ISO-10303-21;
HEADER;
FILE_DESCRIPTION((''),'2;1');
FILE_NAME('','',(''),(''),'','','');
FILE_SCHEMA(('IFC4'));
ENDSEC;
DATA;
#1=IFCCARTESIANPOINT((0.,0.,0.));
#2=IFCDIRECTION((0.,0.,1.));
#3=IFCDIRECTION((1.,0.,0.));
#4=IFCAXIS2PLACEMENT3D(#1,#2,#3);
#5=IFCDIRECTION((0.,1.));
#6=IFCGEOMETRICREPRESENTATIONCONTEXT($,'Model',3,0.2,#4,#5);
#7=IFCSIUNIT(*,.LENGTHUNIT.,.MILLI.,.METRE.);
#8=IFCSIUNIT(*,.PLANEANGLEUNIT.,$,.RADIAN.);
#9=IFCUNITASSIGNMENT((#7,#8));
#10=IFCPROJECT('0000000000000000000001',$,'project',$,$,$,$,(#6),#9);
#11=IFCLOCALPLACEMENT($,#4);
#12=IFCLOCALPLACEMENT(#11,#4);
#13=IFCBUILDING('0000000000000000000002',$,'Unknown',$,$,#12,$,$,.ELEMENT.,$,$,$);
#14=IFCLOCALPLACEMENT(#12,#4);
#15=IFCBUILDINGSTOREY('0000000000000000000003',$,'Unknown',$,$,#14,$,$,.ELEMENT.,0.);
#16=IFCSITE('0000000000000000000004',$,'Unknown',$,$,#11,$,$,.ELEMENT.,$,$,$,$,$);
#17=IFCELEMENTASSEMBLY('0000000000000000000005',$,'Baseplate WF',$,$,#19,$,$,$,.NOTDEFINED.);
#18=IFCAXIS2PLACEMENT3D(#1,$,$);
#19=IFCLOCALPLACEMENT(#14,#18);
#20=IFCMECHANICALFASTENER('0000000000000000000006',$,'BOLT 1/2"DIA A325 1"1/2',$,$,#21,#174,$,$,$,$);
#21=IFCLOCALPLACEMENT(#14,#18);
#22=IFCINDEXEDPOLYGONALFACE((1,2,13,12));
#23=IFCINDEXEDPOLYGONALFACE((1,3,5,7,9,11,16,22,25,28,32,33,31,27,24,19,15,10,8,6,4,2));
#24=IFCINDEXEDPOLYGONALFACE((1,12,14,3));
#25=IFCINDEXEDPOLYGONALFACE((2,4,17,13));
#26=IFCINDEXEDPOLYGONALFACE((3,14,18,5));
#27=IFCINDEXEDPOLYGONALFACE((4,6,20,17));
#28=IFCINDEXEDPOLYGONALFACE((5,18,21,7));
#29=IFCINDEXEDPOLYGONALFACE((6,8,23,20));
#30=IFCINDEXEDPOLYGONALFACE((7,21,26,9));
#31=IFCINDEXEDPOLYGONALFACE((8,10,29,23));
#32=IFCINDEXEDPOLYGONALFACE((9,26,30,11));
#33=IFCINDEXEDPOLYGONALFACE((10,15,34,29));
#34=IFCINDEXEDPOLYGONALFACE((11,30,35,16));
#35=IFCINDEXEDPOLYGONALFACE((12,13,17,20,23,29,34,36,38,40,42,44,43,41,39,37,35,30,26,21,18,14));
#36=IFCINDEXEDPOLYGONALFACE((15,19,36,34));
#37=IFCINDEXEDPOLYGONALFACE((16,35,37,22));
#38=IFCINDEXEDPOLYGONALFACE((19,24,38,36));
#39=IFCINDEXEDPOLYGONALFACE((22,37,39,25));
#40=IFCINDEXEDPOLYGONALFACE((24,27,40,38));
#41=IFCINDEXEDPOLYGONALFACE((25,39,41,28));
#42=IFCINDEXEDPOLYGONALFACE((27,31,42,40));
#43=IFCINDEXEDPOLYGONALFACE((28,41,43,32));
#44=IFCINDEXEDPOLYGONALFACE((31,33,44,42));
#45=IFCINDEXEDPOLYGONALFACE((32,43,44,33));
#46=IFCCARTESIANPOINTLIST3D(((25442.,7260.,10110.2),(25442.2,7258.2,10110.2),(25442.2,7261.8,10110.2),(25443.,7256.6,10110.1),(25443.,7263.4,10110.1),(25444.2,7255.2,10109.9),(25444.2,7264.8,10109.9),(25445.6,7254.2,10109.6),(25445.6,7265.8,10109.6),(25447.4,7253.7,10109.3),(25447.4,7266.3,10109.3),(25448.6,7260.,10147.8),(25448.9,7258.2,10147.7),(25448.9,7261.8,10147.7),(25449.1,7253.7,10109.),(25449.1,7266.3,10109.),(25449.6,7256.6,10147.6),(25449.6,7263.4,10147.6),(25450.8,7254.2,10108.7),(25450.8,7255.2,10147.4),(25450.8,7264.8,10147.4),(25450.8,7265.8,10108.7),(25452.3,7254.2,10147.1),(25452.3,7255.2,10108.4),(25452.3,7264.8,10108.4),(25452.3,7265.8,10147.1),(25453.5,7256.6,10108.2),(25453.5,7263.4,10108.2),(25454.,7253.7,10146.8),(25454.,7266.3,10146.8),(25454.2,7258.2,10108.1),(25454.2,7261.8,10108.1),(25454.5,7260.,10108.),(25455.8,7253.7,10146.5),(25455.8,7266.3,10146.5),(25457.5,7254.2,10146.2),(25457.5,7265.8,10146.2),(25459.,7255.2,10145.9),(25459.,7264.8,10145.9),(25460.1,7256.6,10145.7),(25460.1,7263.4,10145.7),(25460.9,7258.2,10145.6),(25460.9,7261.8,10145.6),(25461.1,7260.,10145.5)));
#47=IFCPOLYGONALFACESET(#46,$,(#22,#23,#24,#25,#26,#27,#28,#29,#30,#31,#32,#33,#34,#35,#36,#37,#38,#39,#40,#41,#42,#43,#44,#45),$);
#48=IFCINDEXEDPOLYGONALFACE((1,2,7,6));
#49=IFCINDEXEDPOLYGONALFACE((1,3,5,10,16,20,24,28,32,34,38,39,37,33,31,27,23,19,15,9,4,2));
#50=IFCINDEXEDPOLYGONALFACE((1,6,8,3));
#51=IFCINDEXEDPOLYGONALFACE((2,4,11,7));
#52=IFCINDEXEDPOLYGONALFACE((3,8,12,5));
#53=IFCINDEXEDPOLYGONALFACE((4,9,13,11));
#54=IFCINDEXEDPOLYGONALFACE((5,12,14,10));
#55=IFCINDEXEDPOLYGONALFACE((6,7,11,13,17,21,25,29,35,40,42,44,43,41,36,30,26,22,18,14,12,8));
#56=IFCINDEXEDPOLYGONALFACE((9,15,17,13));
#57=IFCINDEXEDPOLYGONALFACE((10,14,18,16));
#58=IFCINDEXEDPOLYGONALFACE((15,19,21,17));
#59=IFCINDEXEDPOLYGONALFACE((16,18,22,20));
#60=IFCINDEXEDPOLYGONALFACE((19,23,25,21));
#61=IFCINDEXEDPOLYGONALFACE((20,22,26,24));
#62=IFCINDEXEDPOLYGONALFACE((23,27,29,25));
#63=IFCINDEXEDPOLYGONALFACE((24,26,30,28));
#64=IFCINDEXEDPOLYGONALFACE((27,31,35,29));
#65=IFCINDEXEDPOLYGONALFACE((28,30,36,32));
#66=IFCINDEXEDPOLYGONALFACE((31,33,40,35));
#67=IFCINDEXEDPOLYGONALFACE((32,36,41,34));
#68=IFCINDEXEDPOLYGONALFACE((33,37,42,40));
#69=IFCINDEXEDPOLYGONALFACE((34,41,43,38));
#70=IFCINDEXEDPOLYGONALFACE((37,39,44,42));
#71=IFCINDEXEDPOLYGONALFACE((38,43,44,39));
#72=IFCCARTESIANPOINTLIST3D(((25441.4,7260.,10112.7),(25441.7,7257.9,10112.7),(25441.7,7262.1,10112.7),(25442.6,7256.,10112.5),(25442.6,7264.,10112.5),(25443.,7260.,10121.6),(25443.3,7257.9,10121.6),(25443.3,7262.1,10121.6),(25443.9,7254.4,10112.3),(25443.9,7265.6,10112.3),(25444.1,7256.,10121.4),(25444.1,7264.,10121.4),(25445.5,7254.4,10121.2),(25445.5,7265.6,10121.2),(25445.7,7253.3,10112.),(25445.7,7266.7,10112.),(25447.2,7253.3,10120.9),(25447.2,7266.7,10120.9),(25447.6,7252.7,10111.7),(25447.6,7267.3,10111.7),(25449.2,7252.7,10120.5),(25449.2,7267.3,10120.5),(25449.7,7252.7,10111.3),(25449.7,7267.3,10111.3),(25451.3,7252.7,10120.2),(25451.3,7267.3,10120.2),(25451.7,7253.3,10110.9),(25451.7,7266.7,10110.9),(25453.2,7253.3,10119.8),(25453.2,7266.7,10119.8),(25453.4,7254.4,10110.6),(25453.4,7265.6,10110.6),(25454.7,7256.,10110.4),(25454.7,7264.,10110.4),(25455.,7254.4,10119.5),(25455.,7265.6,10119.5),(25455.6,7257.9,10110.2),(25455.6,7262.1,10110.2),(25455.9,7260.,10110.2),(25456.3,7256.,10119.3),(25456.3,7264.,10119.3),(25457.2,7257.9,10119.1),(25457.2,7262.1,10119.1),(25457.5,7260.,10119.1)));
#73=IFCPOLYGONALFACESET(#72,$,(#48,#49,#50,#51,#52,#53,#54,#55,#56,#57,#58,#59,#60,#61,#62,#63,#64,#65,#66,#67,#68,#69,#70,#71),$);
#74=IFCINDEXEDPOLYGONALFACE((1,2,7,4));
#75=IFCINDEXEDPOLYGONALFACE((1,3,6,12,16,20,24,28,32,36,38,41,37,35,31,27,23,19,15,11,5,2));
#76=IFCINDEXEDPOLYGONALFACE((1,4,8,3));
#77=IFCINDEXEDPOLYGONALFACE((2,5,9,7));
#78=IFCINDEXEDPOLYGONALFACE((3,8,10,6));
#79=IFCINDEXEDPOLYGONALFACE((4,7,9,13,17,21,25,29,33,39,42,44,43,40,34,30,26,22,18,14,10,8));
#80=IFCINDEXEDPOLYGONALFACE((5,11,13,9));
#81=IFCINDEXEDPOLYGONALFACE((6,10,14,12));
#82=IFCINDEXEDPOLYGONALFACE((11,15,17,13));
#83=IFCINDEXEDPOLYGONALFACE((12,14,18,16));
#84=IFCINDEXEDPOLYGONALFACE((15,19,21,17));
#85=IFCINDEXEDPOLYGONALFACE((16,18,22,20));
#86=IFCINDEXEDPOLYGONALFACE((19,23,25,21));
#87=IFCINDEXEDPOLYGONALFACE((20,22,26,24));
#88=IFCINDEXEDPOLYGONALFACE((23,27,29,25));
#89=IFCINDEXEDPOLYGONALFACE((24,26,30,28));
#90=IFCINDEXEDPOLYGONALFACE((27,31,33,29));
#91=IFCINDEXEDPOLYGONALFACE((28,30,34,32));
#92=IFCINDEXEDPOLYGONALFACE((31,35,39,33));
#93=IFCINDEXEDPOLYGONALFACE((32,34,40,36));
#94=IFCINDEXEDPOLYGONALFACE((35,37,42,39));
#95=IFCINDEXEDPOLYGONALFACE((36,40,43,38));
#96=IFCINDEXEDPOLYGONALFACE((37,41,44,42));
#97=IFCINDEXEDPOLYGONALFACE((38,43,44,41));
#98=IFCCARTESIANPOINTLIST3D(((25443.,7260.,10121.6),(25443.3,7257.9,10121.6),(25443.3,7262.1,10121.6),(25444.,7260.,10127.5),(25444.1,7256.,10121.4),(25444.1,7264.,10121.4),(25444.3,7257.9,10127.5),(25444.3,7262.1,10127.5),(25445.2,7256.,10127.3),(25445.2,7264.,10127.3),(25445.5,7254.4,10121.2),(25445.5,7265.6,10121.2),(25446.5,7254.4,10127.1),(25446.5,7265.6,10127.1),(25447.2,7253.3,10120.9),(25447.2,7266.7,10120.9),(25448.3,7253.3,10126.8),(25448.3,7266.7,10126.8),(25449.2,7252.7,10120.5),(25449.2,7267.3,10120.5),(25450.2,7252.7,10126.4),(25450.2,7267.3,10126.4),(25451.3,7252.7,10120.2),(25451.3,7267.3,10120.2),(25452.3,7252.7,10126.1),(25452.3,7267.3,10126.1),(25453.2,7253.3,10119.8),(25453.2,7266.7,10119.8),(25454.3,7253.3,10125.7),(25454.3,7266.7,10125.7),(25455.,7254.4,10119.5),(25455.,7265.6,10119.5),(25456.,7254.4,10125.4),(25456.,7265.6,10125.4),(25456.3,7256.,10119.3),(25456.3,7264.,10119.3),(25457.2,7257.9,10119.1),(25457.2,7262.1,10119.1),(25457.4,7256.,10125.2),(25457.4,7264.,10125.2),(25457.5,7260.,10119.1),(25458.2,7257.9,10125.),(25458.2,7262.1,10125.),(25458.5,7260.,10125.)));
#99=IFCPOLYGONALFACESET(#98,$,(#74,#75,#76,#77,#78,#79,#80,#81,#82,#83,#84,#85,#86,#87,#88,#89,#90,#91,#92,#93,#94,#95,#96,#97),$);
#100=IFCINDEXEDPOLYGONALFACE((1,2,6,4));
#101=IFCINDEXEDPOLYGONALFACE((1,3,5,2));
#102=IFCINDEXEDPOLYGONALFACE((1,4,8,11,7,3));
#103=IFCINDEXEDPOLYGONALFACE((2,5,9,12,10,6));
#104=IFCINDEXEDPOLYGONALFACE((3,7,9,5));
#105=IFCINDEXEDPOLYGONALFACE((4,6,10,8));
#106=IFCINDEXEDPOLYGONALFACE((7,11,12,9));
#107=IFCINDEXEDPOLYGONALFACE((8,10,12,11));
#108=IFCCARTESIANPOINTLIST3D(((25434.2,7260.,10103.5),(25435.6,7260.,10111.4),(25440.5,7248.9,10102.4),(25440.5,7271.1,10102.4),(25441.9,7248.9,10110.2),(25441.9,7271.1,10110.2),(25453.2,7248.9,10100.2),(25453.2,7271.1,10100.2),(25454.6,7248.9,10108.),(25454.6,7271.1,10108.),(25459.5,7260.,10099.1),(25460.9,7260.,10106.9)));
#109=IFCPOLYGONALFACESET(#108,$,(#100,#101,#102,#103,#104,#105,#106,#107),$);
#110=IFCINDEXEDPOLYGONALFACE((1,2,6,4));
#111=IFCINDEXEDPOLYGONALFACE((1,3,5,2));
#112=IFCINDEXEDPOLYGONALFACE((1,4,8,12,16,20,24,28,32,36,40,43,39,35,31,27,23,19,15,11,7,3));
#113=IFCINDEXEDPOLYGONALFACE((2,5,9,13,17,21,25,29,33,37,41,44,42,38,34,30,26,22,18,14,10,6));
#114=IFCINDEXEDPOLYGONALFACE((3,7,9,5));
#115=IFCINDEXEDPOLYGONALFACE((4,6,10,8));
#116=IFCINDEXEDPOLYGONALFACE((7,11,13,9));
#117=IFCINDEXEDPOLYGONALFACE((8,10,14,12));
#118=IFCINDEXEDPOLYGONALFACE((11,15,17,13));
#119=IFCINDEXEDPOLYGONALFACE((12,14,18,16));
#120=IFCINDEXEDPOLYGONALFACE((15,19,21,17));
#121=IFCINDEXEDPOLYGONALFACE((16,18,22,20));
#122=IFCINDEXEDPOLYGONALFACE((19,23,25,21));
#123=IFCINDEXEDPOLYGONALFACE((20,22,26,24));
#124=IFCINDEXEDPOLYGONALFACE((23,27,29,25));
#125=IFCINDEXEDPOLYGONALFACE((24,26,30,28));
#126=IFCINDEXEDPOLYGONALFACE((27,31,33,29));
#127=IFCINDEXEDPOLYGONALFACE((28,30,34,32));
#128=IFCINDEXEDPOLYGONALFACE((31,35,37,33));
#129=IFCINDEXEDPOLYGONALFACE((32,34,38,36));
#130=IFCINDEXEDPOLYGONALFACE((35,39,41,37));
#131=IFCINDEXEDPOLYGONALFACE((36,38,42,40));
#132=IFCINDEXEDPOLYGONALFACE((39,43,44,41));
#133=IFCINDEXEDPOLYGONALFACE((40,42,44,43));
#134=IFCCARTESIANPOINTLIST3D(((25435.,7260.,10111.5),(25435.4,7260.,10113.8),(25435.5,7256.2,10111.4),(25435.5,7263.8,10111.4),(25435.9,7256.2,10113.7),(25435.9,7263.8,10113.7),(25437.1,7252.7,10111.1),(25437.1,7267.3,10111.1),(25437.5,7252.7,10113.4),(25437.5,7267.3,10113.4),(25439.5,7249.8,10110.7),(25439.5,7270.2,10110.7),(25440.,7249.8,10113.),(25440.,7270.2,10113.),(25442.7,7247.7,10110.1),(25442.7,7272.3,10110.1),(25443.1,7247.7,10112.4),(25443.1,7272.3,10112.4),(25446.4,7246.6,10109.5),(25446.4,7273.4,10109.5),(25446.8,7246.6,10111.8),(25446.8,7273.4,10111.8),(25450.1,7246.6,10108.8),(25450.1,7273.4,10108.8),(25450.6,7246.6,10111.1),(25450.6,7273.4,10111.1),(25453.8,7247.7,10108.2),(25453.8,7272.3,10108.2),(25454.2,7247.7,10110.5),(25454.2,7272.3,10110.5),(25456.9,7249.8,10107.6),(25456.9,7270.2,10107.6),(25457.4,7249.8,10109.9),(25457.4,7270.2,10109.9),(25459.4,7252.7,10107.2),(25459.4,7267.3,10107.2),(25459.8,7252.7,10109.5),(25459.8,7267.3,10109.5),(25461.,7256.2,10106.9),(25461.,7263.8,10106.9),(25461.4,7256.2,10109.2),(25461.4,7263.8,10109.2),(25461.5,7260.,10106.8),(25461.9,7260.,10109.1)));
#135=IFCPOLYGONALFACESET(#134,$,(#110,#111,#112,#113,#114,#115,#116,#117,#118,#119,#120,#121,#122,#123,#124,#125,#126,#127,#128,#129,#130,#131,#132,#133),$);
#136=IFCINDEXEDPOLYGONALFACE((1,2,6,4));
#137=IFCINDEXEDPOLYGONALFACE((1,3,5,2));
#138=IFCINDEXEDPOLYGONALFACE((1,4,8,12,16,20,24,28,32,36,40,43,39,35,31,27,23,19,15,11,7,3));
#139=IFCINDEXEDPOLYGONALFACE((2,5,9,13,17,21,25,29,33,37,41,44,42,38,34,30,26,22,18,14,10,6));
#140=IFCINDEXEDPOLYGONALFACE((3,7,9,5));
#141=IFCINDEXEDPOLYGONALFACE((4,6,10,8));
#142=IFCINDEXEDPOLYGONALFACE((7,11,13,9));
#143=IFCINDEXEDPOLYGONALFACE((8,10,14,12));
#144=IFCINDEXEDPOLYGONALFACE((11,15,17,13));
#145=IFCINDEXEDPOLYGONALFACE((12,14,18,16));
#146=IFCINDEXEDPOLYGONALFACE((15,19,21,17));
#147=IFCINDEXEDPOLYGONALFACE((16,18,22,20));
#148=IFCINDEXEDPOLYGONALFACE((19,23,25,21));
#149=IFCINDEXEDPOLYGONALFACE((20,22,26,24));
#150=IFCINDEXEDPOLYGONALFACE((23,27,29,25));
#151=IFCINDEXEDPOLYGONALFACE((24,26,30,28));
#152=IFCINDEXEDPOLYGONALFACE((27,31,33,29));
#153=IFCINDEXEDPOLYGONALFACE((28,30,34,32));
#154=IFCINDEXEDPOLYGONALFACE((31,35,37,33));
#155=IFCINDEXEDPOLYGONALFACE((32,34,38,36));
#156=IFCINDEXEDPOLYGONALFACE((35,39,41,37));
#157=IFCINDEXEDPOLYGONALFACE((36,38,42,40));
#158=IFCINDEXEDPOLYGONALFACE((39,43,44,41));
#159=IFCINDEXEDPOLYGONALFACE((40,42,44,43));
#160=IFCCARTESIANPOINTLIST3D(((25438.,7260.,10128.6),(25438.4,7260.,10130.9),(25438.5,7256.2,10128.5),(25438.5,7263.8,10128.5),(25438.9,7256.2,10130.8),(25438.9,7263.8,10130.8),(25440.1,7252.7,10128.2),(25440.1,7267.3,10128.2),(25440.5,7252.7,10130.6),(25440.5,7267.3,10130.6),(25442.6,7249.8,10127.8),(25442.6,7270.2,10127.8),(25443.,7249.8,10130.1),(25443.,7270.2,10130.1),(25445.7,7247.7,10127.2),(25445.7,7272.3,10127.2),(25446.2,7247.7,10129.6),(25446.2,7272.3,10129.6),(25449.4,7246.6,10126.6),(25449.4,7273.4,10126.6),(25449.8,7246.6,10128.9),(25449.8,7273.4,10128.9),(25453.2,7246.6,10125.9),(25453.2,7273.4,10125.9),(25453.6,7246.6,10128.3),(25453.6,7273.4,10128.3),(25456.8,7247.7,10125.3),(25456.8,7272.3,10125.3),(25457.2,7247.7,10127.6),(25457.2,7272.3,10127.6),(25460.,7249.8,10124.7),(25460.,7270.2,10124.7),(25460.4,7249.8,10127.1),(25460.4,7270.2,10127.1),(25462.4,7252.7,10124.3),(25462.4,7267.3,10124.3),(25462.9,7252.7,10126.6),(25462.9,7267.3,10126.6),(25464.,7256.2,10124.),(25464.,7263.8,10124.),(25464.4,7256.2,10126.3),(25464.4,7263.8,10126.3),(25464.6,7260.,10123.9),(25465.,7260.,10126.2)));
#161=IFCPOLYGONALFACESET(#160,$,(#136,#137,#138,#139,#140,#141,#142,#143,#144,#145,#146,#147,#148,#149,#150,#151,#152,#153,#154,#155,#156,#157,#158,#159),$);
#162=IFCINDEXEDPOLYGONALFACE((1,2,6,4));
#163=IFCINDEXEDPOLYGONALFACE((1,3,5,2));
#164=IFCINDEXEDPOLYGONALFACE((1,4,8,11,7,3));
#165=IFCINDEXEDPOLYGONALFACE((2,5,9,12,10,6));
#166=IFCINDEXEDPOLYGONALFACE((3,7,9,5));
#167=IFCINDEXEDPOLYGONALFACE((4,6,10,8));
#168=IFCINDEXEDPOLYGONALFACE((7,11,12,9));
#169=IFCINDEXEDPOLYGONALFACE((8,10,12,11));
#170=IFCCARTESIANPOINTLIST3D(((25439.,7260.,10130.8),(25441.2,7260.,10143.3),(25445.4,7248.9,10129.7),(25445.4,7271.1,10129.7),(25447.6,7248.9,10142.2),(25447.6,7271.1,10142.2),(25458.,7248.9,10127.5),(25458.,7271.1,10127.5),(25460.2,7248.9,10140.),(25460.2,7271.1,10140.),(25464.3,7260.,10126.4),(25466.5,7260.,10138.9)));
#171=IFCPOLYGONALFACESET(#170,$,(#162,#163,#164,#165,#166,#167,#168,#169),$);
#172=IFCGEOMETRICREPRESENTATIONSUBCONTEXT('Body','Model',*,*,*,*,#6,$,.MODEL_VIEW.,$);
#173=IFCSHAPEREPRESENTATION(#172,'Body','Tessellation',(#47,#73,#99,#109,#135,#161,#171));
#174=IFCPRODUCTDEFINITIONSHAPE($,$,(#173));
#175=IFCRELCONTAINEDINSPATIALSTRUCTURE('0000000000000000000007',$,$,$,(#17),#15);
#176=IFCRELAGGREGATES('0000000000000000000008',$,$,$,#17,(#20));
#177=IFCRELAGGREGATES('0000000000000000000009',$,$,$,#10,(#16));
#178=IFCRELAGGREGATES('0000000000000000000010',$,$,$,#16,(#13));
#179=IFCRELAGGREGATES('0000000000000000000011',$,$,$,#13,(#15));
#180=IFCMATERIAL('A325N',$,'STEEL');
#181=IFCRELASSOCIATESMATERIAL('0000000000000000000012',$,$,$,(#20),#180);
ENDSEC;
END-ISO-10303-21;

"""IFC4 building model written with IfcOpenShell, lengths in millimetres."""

from ifc_helpers import new_model, si_unit, direction, frame, origin_with_axes, place, context, subcontext, project, spatial, line, arc, indexed_curve, outline, extrude, source, transform, mapped, material, element, aggregate, save


model = new_model("IFC4")

# Units and contexts
model_context = context("Model", 3, precision=0.2, world=origin_with_axes(), true_north=direction((0.0, 1.0)))
body_context = subcontext(model_context, "Body", "Model", "MODEL_VIEW")
ifc_project = project(units=[si_unit("LENGTHUNIT", "METRE", prefix="MILLI"), si_unit("PLANEANGLEUNIT", "RADIAN")], contexts=[model_context])

# Site, building, storey
site_placement = place(None, origin_with_axes())
site = spatial("IfcSite", under=ifc_project, at=site_placement, Name="Unknown", CompositionType="ELEMENT")
building_placement = place(site_placement, origin_with_axes())
building = spatial("IfcBuilding", under=site, at=building_placement, Name="Unknown", CompositionType="ELEMENT")
storey_placement = place(building_placement, origin_with_axes())
storey = spatial("IfcBuildingStorey", under=building, at=storey_placement, Name="Unknown", CompositionType="ELEMENT", Elevation=0.0)

# Element assembly
assembly_1_placement = place(storey_placement, frame((25480.3, 7290.0, 10118.1), z_axis=(-0.173648, 0.0, -0.984808), x_axis=(0.0, -1.0, 0.0)))
assembly_1 = element("IfcElementAssembly", 1, at=assembly_1_placement, inside=storey, Name="Baseplate WF", PredefinedType="NOTDEFINED")

# Mechanical fastener
ifc_material_1 = material(Name="A325N", Category="STEEL")
shared_shape_1 = source(origin_with_axes(), body_context, "Body", "SweptSolid", [
    extrude(outline(indexed_curve([(6.3, 0.0), (0.0, 6.3), (-6.3, 0.0), (0.0, -6.3)], segments=[arc(1, 2, 3), arc(3, 4, 1)])), frame((0.0, 0.0, 17.4), z_axis=(0.0, 0.0, -1.0), x_axis=(0.0, 1.0, 0.0)), (0.0, 0.0, 1.0), 38.1),
    extrude(outline(indexed_curve([(7.3, 0.0), (0.0, 7.3), (-7.3, 0.0), (0.0, -7.3)], segments=[arc(1, 2, 3), arc(3, 4, 1)])), frame((0.0, 0.0, 15.0), z_axis=(0.0, 0.0, -1.0), x_axis=(0.0, 1.0, 0.0)), (0.0, 0.0, 1.0), 9.0),
    extrude(outline(indexed_curve([(7.3, 0.0), (0.0, 7.3), (-7.3, 0.0), (0.0, -7.3)], segments=[arc(1, 2, 3), arc(3, 4, 1)])), frame((0.0, 0.0, 6.0), z_axis=(0.0, 0.0, -1.0), x_axis=(0.0, 1.0, 0.0)), (0.0, 0.0, 1.0), 6.0),
    extrude(outline(indexed_curve([(12.8, 0.0), (6.4, 11.1), (-6.4, 11.1), (-12.8, 0.0), (-6.4, -11.1), (6.4, -11.1)], segments=[line(1, 2, 3, 4, 5, 6, 1)])), frame((0.0, 0.0, 25.3), z_axis=(0.0, 0.0, -1.0), x_axis=(0.0, 1.0, 0.0)), (0.0, 0.0, 1.0), 7.9),
    extrude(outline(indexed_curve([(13.5, 0.0), (0.0, 13.5), (-13.5, 0.0), (0.0, -13.5)], segments=[arc(1, 2, 3), arc(3, 4, 1)])), frame((0.0, 0.0, 17.4), z_axis=(0.0, 0.0, -1.0), x_axis=(0.0, 1.0, 0.0)), (0.0, 0.0, 1.0), 2.4),
    extrude(outline(indexed_curve([(13.5, 0.0), (0.0, 13.5), (-13.5, 0.0), (0.0, -13.5)], segments=[arc(1, 2, 3), arc(3, 4, 1)])), frame((0.0, 0.0, 0.0), z_axis=(0.0, 0.0, -1.0), x_axis=(0.0, 1.0, 0.0)), (0.0, 0.0, 1.0), 2.4),
    extrude(outline(indexed_curve([(12.8, 0.0), (6.4, 11.1), (-6.4, 11.1), (-12.8, 0.0), (-6.4, -11.1), (6.4, -11.1)], segments=[line(1, 2, 3, 4, 5, 6, 1)])), frame((0.0, 0.0, -2.4), z_axis=(0.0, 0.0, -1.0), x_axis=(0.0, 1.0, 0.0)), (0.0, 0.0, 1.0), 12.7),
])
mechanical_fastener_1_placement = place(assembly_1_placement, frame((30.0, 30.0, -3.0), z_axis=(0.0, 0.0, 1.0), x_axis=(-1.0, 0.0, 0.0)))
mechanical_fastener_1 = element("IfcMechanicalFastener", 2, at=mechanical_fastener_1_placement, material=ifc_material_1, Name="BOLT 1/2\"DIA A325 1\"1/2", context=body_context, shape_type="MappedRepresentation", body=[
    mapped(shared_shape_1, transform((0.0, 0.0, 0.0))),
])
aggregate(assembly_1, [mechanical_fastener_1])

save(model, "model.ifc")
